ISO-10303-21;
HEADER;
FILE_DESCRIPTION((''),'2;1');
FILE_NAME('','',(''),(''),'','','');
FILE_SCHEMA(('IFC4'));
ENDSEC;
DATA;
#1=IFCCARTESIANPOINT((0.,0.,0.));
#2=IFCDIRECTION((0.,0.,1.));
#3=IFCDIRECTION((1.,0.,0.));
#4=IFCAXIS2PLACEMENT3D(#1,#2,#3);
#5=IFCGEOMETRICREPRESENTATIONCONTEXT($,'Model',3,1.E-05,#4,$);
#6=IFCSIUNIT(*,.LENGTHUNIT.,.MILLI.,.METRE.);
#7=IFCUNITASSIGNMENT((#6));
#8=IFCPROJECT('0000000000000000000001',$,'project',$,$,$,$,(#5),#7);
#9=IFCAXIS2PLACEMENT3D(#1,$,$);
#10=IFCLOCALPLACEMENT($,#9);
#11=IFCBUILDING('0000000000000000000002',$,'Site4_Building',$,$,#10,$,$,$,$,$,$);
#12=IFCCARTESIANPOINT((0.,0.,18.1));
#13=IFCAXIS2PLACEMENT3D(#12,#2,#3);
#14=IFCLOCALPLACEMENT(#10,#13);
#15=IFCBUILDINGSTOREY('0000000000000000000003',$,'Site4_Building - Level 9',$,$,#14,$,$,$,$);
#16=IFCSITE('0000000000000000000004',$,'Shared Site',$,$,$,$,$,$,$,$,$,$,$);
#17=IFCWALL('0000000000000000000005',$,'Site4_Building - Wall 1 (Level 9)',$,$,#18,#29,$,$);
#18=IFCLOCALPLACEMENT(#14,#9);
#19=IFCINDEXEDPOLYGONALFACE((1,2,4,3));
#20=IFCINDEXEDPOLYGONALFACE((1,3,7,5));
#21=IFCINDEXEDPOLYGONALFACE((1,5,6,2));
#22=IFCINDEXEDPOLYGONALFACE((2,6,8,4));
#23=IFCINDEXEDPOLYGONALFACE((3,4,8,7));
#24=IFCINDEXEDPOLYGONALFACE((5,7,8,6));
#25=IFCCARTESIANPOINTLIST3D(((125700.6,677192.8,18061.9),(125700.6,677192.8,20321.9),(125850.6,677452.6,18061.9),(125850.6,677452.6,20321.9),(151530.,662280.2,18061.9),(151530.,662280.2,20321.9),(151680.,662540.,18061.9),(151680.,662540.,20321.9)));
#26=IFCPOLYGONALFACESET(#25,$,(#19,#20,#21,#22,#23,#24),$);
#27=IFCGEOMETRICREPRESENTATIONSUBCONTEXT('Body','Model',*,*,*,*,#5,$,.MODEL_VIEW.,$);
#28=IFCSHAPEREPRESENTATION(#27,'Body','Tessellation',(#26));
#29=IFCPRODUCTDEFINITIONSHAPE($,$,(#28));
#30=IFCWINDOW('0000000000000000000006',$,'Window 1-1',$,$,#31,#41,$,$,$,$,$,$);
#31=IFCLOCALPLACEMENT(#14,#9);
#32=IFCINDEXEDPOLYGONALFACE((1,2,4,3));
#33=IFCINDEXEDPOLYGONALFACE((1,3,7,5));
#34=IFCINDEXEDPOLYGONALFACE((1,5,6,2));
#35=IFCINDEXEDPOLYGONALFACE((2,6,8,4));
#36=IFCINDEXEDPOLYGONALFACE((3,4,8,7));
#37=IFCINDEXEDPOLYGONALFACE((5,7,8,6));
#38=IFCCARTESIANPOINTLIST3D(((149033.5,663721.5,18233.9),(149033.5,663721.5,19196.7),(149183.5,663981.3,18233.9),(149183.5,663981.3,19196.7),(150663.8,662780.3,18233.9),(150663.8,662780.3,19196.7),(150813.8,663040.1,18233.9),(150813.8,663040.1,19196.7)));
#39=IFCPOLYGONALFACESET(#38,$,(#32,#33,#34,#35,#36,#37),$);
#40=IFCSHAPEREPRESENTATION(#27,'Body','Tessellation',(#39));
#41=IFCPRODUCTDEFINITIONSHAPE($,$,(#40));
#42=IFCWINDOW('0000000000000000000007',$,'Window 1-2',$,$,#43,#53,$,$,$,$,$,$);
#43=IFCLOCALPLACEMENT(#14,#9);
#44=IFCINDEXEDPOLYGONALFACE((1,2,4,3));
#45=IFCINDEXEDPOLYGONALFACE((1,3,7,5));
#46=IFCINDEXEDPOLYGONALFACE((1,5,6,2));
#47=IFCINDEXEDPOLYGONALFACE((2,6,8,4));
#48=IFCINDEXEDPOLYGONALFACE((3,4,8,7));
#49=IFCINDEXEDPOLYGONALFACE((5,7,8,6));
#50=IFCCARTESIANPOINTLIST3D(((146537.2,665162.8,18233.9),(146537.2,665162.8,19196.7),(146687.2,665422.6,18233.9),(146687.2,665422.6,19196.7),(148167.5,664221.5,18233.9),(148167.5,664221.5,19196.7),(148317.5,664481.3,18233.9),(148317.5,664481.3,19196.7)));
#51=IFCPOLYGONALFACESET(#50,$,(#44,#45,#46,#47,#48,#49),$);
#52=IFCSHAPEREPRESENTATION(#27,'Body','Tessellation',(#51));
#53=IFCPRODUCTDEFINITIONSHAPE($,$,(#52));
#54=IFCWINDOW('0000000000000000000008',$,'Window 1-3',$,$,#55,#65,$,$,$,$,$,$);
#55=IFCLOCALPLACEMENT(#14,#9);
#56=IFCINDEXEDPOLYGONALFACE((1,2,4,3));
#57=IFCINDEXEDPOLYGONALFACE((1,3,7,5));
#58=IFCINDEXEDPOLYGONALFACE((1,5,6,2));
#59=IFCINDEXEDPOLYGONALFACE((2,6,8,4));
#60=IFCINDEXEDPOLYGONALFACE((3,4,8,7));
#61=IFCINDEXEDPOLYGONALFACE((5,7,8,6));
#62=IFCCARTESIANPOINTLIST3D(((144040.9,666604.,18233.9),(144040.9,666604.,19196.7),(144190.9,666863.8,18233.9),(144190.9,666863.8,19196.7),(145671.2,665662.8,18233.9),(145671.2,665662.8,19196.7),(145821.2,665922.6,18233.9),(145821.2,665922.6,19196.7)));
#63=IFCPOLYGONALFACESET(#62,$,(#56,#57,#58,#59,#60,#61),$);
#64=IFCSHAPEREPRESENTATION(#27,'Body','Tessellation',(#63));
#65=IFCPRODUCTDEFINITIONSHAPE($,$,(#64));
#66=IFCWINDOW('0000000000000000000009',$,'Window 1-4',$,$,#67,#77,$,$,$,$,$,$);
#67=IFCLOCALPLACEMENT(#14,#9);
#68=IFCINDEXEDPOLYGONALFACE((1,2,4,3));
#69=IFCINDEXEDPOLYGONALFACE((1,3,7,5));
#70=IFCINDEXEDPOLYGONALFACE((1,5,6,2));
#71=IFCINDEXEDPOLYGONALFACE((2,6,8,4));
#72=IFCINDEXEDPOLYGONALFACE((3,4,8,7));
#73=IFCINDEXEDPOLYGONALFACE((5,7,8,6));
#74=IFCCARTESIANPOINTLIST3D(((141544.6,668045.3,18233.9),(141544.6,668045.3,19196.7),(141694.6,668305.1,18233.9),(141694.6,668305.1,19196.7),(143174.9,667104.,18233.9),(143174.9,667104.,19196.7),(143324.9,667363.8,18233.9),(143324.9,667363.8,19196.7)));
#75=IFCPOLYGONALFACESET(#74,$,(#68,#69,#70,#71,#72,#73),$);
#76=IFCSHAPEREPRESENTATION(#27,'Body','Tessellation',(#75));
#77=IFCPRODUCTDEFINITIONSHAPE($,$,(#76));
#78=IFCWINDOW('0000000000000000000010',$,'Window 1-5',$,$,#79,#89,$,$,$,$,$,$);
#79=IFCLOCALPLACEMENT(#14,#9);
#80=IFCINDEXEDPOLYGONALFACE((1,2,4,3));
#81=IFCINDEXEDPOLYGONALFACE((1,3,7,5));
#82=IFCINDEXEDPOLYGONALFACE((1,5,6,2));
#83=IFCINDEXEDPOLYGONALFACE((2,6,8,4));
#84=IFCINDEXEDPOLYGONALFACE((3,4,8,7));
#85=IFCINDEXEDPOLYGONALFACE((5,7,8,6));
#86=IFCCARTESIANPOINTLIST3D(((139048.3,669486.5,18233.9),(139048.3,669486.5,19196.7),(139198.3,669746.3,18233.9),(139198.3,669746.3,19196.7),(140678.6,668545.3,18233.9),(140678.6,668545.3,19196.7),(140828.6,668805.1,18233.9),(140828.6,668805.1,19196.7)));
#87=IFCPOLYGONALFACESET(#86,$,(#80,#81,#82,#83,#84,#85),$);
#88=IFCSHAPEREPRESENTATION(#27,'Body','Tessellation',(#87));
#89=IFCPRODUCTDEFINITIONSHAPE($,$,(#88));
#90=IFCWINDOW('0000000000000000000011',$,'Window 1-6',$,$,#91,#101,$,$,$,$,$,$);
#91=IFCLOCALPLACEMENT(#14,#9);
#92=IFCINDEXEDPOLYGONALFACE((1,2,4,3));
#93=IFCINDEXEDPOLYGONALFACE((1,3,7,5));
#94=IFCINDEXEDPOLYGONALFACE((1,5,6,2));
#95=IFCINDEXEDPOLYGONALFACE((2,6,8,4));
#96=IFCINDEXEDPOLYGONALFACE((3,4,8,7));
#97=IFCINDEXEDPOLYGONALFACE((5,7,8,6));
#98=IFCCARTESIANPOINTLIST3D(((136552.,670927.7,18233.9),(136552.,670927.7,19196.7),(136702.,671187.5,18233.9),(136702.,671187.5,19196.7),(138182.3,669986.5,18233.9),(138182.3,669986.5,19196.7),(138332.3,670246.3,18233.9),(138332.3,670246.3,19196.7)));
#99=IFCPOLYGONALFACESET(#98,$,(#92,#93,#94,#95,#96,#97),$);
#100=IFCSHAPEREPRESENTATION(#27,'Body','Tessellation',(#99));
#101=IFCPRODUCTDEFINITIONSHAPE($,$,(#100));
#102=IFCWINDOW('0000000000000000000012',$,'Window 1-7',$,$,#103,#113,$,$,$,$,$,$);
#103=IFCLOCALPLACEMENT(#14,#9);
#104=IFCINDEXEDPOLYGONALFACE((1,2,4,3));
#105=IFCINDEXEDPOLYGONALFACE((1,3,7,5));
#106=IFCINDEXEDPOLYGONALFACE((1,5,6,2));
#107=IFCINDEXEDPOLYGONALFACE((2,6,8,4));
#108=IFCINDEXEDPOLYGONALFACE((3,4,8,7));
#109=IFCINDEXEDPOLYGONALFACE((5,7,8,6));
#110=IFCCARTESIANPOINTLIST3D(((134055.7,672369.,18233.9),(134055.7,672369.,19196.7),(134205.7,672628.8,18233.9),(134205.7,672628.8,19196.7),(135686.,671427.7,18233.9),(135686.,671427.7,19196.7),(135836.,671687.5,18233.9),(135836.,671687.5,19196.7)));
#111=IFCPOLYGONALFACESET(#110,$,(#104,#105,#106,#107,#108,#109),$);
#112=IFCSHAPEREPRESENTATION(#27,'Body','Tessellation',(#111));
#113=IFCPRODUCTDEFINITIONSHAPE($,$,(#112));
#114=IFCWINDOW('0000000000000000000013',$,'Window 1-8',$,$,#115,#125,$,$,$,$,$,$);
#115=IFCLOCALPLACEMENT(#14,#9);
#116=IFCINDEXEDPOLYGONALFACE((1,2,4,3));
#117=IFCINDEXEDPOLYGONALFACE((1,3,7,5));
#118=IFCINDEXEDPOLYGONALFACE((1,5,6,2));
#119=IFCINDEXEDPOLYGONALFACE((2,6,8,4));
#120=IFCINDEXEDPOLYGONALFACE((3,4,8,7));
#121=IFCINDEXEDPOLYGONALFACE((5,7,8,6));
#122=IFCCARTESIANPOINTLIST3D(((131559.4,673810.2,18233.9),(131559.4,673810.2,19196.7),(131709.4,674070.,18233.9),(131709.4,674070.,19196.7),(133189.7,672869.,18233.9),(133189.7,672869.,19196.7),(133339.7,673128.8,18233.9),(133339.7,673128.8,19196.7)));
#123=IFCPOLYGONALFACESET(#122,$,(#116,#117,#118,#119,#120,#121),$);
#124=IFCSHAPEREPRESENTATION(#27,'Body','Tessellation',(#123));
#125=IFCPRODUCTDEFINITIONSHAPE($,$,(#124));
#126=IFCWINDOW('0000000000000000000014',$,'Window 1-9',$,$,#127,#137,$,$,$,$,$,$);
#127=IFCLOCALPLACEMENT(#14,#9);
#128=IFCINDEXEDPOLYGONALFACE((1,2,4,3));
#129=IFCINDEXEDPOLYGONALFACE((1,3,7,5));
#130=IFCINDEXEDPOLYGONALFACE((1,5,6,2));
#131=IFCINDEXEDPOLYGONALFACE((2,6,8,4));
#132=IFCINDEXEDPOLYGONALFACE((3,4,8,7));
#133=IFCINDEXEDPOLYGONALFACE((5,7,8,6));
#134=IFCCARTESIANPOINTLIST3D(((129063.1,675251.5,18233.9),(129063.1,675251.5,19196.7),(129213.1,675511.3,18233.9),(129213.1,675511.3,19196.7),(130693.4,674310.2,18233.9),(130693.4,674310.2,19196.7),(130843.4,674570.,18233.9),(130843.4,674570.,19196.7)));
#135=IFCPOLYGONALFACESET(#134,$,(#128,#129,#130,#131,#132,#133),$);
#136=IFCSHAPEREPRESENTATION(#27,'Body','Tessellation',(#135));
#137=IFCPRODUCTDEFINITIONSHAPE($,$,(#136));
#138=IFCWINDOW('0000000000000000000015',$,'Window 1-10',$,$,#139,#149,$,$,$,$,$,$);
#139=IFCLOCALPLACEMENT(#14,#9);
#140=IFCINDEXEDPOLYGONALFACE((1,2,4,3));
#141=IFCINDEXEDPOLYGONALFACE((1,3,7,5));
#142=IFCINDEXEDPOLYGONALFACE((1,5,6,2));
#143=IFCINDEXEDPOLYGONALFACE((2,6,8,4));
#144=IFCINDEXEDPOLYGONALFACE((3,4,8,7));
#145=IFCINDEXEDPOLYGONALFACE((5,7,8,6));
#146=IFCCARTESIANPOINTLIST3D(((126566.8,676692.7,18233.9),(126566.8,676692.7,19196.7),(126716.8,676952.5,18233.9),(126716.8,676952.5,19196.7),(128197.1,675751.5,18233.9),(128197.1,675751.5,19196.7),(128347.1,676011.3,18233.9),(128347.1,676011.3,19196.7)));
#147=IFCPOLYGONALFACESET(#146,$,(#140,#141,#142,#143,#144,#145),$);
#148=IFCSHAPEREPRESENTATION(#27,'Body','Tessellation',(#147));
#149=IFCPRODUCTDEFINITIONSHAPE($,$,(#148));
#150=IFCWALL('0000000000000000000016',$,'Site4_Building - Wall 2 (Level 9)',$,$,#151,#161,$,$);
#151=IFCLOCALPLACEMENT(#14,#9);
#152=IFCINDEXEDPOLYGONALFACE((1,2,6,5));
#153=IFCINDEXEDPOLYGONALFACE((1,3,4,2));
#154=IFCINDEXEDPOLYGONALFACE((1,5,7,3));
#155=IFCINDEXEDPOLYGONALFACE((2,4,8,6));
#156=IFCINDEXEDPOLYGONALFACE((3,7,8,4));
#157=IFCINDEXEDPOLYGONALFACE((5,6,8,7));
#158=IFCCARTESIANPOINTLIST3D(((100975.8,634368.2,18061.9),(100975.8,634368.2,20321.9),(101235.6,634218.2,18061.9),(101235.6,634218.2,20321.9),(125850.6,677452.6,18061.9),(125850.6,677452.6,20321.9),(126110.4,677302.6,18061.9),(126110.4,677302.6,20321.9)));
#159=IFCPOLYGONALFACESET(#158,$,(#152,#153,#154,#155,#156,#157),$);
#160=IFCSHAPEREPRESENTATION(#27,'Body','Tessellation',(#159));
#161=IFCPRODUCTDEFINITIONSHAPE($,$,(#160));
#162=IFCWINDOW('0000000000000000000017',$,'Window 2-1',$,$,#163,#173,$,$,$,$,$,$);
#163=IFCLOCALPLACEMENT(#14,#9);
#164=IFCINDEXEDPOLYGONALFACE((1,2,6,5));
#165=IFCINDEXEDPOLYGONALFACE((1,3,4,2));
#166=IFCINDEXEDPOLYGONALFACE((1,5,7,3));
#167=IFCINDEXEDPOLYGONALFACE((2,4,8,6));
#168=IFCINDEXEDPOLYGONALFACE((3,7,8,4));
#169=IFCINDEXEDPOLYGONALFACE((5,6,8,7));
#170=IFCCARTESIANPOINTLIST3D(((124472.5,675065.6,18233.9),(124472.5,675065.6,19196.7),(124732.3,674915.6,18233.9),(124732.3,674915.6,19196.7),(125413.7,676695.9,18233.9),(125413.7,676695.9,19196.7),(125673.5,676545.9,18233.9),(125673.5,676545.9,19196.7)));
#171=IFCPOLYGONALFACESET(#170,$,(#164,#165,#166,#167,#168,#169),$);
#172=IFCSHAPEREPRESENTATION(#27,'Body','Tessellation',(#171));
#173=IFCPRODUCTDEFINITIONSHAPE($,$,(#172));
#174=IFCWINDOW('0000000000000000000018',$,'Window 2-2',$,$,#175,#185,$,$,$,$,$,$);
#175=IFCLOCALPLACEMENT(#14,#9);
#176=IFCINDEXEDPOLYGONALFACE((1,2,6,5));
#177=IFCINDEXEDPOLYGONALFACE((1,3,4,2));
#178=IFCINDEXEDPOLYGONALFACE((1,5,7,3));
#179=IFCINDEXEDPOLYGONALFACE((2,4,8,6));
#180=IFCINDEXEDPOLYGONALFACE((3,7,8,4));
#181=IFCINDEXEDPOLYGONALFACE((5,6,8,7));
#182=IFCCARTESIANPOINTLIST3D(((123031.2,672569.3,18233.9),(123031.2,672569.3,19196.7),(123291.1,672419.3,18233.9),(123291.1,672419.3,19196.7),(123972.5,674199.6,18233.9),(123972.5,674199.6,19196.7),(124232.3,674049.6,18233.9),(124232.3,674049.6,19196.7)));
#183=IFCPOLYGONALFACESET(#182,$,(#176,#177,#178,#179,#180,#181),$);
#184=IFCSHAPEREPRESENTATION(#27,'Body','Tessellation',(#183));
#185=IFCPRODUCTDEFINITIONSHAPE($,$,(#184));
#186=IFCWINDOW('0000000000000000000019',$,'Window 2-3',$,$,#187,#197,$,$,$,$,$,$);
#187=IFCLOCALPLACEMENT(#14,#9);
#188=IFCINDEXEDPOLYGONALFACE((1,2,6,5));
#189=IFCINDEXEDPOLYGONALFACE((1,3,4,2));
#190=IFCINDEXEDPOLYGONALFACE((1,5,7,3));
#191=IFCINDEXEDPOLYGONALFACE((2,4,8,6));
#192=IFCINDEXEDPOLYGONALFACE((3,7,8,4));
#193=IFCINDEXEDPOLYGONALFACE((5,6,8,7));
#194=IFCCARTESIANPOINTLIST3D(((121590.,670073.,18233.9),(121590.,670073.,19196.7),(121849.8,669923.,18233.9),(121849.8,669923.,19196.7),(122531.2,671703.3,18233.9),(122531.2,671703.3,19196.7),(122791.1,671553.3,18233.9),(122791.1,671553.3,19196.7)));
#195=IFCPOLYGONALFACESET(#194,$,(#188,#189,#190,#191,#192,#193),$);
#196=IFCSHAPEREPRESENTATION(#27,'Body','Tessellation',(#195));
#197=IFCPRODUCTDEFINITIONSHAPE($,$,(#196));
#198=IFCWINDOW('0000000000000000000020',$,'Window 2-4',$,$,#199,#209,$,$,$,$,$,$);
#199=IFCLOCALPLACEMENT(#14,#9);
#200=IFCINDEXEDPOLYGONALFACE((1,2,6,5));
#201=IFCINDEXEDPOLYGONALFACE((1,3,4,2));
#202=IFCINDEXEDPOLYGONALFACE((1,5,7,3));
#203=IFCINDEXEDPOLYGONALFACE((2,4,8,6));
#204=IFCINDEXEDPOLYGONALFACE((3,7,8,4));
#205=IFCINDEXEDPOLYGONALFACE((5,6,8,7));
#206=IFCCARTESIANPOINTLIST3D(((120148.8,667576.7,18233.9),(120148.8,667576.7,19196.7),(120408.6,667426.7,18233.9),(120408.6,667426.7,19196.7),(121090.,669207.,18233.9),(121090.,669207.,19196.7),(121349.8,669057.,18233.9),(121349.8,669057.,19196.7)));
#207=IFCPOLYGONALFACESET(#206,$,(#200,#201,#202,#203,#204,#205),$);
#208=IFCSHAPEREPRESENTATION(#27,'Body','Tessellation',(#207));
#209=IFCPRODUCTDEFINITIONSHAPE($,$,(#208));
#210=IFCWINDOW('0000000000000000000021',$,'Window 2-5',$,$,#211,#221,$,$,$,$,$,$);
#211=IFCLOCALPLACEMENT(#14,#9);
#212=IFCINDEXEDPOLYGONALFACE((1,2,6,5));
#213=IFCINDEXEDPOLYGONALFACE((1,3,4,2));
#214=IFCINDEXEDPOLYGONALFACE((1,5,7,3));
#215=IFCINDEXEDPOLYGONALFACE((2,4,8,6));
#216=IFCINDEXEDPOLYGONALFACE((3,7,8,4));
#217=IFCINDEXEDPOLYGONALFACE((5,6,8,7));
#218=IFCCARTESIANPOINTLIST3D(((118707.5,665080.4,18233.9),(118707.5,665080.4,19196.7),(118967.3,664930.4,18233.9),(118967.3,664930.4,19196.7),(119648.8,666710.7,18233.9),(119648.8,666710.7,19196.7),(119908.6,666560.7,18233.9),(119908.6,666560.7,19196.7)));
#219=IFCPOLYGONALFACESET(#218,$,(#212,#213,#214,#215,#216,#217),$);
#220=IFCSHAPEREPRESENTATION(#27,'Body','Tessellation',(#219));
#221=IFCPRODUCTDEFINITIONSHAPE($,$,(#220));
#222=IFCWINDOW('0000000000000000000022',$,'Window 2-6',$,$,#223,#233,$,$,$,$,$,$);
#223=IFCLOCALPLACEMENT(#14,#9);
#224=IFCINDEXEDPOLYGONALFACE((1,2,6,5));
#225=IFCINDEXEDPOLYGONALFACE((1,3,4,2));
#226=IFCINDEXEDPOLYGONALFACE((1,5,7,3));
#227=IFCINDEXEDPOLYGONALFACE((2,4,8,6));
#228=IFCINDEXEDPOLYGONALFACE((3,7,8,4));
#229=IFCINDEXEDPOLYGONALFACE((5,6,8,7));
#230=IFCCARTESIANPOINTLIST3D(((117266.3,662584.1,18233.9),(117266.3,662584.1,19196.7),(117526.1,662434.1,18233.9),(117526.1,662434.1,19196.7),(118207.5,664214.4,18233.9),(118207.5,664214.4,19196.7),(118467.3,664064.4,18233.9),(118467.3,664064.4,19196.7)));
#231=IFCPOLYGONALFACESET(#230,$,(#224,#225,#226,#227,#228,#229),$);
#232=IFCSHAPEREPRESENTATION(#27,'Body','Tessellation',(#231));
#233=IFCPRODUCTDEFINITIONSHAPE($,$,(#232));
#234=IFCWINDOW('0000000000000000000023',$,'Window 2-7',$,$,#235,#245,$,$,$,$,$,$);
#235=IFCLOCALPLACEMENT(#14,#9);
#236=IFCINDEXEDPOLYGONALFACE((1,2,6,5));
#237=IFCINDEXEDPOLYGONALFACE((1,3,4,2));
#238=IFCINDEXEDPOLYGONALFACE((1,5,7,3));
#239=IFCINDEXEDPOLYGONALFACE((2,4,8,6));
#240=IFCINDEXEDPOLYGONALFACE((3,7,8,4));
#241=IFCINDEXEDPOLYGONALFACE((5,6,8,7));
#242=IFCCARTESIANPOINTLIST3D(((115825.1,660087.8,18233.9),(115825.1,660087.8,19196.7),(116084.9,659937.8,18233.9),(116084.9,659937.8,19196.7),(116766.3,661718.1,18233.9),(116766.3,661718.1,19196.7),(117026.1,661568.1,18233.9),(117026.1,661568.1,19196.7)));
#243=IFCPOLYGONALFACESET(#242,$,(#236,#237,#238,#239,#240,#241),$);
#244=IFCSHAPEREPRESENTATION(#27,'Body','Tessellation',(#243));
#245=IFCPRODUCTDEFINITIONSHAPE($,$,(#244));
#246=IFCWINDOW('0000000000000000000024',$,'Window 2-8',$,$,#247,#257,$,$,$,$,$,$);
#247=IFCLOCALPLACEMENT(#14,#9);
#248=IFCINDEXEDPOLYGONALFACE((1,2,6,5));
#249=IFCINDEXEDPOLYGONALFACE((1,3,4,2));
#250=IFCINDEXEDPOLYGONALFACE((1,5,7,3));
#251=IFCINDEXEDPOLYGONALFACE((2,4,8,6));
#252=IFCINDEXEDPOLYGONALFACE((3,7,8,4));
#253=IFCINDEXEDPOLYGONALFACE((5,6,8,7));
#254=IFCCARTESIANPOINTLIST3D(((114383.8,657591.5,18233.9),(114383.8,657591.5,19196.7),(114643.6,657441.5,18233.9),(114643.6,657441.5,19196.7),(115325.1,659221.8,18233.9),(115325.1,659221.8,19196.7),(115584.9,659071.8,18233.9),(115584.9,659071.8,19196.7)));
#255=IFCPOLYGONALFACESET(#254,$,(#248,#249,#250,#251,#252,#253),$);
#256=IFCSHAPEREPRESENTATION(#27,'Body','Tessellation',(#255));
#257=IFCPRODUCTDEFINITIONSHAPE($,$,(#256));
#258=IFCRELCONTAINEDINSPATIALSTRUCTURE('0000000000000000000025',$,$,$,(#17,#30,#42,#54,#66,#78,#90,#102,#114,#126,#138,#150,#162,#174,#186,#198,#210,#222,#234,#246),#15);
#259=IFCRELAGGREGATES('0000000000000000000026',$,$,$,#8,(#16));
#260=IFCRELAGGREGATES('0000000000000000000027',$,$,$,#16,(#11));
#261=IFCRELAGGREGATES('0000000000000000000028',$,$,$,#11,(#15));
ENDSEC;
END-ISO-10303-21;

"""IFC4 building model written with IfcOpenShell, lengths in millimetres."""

from ifc_helpers import new_model, si_unit, frame, origin, origin_with_axes, place, context, subcontext, project, spatial, indexed_curve, outline, extrude, element, save


model = new_model("IFC4")

# Units and contexts
model_context = context("Model", 3, precision=1e-05, world=origin_with_axes())
body_context = subcontext(model_context, "Body", "Model", "MODEL_VIEW")
ifc_project = project(units=[si_unit("LENGTHUNIT", "METRE", prefix="MILLI")], contexts=[model_context])

# Site, building, storey
site = spatial("IfcSite", under=ifc_project, Name="Shared Site")
building_placement = place(None, origin())
building = spatial("IfcBuilding", under=site, at=building_placement, Name="Site4_Building")
storey_placement = place(building_placement, frame((0.0, 0.0, 18.1), z_axis=(0.0, 0.0, 1.0), x_axis=(1.0, 0.0, 0.0)))
storey = spatial("IfcBuildingStorey", under=building, at=storey_placement, Name="Site4_Building - Level 9")

# Wall
wall_1_placement = place(storey_placement, frame((151680.0, 662540.0, 18061.9), z_axis=(0.0, 0.0, 1.0), x_axis=(-0.866025, 0.5, 0.0)))
element("IfcWall", 1, at=wall_1_placement, inside=storey, Name="Site4_Building - Wall 1 (Level 9)", context=body_context, shape_type="SweptSolid", body=[
    extrude(outline(indexed_curve([(0.0, 0.0), (0.0, 300.0), (29825.2, 300.0), (29825.2, 0.0), (0.0, 0.0)], self_intersect=False)), origin_with_axes(), (0.0, 0.0, 1.0), 2260.0),
])

# Windows
for number, where, z_axis, x_axis, name in (
    (2, (150813.8, 663040.1, 18233.9), (0.0, 0.0, 1.0), (-0.866025, 0.5, 0.0), "Window 1-1"),
    (3, (148317.5, 664481.3, 18233.9), (0.0, 0.0, 1.0), (-0.866025, 0.5, 0.0), "Window 1-2"),
    (4, (145821.2, 665922.6, 18233.9), (0.0, 0.0, 1.0), (-0.866025, 0.5, 0.0), "Window 1-3"),
    (5, (143324.9, 667363.8, 18233.9), (0.0, 0.0, 1.0), (-0.866025, 0.5, 0.0), "Window 1-4"),
    (6, (140828.6, 668805.1, 18233.9), (0.0, 0.0, 1.0), (-0.866025, 0.5, 0.0), "Window 1-5"),
    (7, (138332.3, 670246.3, 18233.9), (0.0, 0.0, 1.0), (-0.866025, 0.5, 0.0), "Window 1-6"),
    (8, (135836.0, 671687.5, 18233.9), (0.0, 0.0, 1.0), (-0.866025, 0.5, 0.0), "Window 1-7"),
    (9, (133339.7, 673128.8, 18233.9), (0.0, 0.0, 1.0), (-0.866025, 0.5, 0.0), "Window 1-8"),
    (10, (130843.4, 674570.0, 18233.9), (0.0, 0.0, 1.0), (-0.866025, 0.5, 0.0), "Window 1-9"),
    (11, (128347.1, 676011.3, 18233.9), (0.0, 0.0, 1.0), (-0.866025, 0.5, 0.0), "Window 1-10"),
):
    element("IfcWindow", number, at=place(storey_placement, frame(where, z_axis=z_axis, x_axis=x_axis)), inside=storey, Name=name, context=body_context, shape_type="SweptSolid", body=[
        extrude(outline(indexed_curve([(0.0, 0.0), (0.0, 300.0), (1882.5, 300.0), (1882.5, 0.0), (0.0, 0.0)], self_intersect=False)), origin_with_axes(), (0.0, 0.0, 1.0), 962.8),
    ])

# Wall
wall_2_placement = place(storey_placement, frame((125850.6, 677452.6, 18061.9), z_axis=(0.0, 0.0, 1.0), x_axis=(-0.5, -0.866025, 0.0)))
element("IfcWall", 12, at=wall_2_placement, inside=storey, Name="Site4_Building - Wall 2 (Level 9)", context=body_context, shape_type="SweptSolid", body=[
    extrude(outline(indexed_curve([(0.0, 0.0), (0.0, 300.0), (49749.6, 300.0), (49749.6, 0.0), (0.0, 0.0)], self_intersect=False)), origin_with_axes(), (0.0, 0.0, 1.0), 2260.0),
])

# Windows
for number, where, z_axis, x_axis, name in (
    (13, (125413.7, 676695.9, 18233.9), (0.0, 0.0, 1.0), (-0.5, -0.866025, 0.0), "Window 2-1"),
    (14, (123972.5, 674199.6, 18233.9), (0.0, 0.0, 1.0), (-0.5, -0.866025, 0.0), "Window 2-2"),
    (15, (122531.2, 671703.3, 18233.9), (0.0, 0.0, 1.0), (-0.5, -0.866025, 0.0), "Window 2-3"),
    (16, (121090.0, 669207.0, 18233.9), (0.0, 0.0, 1.0), (-0.5, -0.866025, 0.0), "Window 2-4"),
    (17, (119648.8, 666710.7, 18233.9), (0.0, 0.0, 1.0), (-0.5, -0.866025, 0.0), "Window 2-5"),
    (18, (118207.5, 664214.4, 18233.9), (0.0, 0.0, 1.0), (-0.5, -0.866025, 0.0), "Window 2-6"),
    (19, (116766.3, 661718.1, 18233.9), (0.0, 0.0, 1.0), (-0.5, -0.866025, 0.0), "Window 2-7"),
    (20, (115325.1, 659221.8, 18233.9), (0.0, 0.0, 1.0), (-0.5, -0.866025, 0.0), "Window 2-8"),
):
    element("IfcWindow", number, at=place(storey_placement, frame(where, z_axis=z_axis, x_axis=x_axis)), inside=storey, Name=name, context=body_context, shape_type="SweptSolid", body=[
        extrude(outline(indexed_curve([(0.0, 0.0), (0.0, 300.0), (1882.5, 300.0), (1882.5, 0.0), (0.0, 0.0)], self_intersect=False)), origin_with_axes(), (0.0, 0.0, 1.0), 962.8),
    ])

save(model, "model.ifc")
